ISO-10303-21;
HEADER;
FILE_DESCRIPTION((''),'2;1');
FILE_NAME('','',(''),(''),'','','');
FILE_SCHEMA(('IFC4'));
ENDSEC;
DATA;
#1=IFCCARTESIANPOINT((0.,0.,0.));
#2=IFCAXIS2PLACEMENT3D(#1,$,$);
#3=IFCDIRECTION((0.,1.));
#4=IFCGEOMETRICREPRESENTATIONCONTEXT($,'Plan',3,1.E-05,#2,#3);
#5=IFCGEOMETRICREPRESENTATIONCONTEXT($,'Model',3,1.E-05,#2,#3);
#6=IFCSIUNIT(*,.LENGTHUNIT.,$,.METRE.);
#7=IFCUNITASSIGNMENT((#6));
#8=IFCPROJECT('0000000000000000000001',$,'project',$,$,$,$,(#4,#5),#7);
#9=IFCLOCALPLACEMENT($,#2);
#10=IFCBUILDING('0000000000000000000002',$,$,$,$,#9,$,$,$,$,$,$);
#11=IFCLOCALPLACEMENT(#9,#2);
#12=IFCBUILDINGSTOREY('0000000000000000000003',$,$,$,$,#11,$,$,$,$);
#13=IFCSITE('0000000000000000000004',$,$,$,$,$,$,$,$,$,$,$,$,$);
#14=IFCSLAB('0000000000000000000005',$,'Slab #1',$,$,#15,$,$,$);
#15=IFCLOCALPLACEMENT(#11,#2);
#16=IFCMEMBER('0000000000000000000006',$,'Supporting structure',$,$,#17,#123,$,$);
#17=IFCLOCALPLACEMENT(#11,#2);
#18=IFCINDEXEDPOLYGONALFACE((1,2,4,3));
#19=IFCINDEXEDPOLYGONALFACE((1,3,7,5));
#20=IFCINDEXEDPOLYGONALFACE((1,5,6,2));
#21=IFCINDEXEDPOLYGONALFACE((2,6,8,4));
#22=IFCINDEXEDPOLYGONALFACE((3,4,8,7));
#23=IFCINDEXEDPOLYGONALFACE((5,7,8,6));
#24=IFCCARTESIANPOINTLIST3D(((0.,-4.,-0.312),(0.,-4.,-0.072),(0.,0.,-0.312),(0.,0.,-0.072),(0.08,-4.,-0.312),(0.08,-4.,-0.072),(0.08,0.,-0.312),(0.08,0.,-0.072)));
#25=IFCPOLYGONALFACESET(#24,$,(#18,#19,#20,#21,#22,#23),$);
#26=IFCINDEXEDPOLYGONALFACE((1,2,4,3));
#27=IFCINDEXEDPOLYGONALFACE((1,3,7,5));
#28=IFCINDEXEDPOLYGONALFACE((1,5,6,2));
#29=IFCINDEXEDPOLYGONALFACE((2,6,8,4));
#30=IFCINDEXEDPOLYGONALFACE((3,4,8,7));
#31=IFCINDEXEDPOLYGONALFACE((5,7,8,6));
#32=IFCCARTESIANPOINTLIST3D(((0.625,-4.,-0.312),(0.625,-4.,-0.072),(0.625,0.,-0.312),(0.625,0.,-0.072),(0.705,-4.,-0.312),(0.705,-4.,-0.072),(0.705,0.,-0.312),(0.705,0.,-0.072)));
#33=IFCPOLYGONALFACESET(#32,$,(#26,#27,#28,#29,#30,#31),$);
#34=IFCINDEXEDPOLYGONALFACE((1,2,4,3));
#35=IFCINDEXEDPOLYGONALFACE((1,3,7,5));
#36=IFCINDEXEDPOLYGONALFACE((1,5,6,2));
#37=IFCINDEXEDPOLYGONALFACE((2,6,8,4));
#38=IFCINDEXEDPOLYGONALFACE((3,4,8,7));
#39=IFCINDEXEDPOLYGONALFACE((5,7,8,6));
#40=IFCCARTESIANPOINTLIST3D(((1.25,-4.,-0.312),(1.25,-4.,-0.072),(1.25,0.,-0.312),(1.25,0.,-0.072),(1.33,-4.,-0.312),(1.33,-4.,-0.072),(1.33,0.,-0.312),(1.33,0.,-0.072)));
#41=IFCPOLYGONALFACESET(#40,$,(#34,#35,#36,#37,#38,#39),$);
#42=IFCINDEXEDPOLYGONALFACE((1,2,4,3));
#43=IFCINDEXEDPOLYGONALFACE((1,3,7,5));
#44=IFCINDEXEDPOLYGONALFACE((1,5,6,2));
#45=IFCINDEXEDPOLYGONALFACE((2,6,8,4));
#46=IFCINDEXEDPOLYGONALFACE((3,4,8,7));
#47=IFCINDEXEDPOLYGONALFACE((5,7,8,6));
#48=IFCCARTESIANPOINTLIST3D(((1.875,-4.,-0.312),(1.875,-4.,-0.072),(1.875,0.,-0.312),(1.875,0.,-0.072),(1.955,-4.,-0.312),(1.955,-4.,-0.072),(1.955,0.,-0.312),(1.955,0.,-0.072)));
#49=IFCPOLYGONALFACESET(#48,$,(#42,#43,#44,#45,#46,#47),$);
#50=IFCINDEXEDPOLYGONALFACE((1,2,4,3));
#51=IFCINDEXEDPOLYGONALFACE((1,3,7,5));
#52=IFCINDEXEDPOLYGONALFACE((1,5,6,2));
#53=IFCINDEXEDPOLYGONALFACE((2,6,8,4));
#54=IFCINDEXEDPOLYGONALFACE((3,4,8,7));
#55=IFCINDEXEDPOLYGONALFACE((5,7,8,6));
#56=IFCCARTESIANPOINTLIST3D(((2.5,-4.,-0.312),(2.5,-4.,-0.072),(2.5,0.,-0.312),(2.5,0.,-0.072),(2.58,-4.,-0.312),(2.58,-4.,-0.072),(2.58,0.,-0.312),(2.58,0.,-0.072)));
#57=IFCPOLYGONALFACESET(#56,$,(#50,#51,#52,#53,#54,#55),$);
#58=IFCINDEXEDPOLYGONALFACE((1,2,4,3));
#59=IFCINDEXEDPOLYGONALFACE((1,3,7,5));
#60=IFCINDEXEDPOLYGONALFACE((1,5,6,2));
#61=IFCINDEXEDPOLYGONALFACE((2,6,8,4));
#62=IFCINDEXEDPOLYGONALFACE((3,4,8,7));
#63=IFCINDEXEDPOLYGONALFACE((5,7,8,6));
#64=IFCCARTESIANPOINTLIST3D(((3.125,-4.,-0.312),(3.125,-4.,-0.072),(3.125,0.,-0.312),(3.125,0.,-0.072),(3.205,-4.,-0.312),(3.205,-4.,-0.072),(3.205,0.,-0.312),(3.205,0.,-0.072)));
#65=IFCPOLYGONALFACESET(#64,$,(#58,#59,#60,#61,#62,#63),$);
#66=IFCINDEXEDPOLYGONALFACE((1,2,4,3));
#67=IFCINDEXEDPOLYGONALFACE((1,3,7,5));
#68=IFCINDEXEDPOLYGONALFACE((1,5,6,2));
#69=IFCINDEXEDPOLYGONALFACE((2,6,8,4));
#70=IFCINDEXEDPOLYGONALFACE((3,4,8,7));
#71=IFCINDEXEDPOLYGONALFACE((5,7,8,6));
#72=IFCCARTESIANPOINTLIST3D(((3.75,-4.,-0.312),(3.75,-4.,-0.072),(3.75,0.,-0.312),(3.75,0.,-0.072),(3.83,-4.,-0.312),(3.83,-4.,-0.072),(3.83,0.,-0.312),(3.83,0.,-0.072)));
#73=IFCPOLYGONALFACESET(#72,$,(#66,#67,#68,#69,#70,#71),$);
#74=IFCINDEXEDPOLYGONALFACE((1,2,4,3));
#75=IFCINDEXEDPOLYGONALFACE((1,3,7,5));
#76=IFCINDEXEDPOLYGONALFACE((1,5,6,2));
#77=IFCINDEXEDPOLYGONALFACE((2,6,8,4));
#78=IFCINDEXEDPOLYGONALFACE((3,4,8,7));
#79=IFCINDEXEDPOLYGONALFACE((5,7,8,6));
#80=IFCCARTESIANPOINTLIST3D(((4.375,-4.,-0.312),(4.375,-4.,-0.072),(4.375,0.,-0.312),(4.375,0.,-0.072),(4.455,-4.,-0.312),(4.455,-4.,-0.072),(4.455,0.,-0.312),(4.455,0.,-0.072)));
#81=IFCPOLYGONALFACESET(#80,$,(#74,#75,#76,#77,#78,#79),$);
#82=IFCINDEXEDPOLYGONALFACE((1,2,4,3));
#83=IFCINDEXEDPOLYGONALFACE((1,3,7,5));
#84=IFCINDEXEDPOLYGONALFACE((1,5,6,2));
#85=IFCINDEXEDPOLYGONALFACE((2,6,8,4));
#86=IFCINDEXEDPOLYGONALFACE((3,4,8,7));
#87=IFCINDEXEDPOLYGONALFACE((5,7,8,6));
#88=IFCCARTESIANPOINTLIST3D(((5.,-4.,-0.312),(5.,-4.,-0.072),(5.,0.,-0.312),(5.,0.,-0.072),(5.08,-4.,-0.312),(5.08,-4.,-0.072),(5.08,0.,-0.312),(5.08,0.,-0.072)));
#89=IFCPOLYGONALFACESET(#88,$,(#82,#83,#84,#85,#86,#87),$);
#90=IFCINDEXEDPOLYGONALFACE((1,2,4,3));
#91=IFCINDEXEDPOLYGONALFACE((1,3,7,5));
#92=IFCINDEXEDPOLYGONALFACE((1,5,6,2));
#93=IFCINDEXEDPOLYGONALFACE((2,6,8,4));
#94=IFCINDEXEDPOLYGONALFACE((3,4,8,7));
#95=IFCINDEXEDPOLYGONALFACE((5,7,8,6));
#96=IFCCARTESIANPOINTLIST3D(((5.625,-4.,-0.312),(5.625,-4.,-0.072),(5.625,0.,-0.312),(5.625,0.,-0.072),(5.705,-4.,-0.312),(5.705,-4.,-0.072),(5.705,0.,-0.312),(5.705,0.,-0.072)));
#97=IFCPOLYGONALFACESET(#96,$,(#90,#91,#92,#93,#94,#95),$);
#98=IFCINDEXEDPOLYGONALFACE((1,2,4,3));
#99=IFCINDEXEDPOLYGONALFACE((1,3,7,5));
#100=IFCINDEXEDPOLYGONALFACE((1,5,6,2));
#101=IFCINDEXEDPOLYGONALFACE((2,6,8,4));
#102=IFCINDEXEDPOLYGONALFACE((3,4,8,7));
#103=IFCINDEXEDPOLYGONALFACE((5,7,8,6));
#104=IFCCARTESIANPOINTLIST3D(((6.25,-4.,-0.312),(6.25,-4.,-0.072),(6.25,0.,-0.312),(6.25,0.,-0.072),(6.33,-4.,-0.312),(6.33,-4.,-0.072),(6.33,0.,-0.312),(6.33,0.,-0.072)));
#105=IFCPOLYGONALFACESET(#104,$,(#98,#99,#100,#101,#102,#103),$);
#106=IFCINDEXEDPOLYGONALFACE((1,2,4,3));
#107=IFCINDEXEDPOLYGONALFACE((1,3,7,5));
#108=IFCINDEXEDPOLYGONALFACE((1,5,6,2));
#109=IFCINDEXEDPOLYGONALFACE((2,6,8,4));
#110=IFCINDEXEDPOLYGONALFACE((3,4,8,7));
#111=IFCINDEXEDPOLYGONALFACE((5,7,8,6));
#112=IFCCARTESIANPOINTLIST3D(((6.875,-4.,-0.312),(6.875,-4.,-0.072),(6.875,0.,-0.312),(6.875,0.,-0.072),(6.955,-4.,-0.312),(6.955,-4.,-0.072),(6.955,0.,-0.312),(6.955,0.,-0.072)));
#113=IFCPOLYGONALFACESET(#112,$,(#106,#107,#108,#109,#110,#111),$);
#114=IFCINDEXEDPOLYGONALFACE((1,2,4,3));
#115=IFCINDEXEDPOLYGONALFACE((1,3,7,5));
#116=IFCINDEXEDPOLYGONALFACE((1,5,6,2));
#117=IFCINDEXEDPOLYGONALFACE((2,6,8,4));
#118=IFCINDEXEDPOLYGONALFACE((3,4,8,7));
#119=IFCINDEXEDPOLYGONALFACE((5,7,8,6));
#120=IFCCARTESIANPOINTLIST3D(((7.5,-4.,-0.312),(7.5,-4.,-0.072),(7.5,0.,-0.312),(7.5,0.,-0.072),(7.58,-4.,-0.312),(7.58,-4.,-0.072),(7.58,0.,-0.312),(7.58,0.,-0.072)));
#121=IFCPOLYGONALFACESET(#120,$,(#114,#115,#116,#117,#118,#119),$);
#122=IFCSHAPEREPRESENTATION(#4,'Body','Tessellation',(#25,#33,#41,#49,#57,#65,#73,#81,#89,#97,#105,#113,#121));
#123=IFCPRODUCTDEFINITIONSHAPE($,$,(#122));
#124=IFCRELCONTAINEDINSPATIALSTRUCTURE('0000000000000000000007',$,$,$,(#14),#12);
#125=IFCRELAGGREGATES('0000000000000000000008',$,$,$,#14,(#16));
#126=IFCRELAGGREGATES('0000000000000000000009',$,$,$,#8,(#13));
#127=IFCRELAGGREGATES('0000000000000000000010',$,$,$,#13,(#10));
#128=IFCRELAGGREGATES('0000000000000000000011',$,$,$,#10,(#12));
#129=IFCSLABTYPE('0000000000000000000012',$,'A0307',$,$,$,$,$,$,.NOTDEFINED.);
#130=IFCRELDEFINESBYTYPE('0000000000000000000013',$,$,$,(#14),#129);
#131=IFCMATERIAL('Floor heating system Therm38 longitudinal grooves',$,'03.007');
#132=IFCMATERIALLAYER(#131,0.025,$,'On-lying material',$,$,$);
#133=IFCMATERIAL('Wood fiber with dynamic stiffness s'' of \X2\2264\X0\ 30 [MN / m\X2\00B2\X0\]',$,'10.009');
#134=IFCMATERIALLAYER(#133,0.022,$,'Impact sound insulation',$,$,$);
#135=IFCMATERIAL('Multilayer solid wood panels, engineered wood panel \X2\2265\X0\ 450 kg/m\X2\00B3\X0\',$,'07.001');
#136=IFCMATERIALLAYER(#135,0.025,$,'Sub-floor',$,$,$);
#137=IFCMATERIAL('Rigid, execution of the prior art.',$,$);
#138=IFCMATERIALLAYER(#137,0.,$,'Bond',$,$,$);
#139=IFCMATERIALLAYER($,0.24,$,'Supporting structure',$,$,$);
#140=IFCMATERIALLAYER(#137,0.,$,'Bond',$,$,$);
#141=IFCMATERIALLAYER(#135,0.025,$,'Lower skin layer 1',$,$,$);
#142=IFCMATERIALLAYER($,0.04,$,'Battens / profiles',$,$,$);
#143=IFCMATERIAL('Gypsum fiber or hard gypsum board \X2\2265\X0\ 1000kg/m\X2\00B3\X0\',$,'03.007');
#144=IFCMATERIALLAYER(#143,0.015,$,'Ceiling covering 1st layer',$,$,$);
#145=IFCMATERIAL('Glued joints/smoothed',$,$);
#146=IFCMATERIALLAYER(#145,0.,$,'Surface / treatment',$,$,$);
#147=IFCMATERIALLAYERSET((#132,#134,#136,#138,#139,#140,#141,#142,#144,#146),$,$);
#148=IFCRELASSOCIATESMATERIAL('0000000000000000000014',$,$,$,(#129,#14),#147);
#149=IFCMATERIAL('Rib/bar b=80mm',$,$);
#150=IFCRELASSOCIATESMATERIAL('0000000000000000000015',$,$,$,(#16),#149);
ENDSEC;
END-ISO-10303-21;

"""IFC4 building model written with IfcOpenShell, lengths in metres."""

from ifc_helpers import new_model, si_unit, direction, frame, frame_2d, origin, place, context, project, spatial, rectangle, extrude, material, layer, layer_set, type_object, element, aggregate, save


model = new_model("IFC4")

# Units and contexts
plan_context = context("Plan", 3, precision=1e-05, world=origin(), true_north=direction((0.0, 1.0)))
model_context = context("Model", 3, precision=1e-05, world=origin(), true_north=direction((0.0, 1.0)))
ifc_project = project(units=[si_unit("LENGTHUNIT", "METRE")], contexts=[plan_context, model_context])

# Site, building, storey
site = spatial("IfcSite", under=ifc_project)
building_placement = place(None, origin())
building = spatial("IfcBuilding", under=site, at=building_placement)
storey_placement = place(building_placement, origin())
storey = spatial("IfcBuildingStorey", under=building, at=storey_placement)

# Slab, member
ifc_material_1 = material(Name="Floor heating system Therm38 longitudinal grooves", Category="03.007")
ifc_layer_1 = layer(ifc_material_1, 0.025, Name="On-lying material")
ifc_material_2 = material(Name="Wood fiber with dynamic stiffness s' of ≤ 30 [MN / m²]", Category="10.009")
ifc_layer_2 = layer(ifc_material_2, 0.022, Name="Impact sound insulation")
ifc_material_3 = material(Name="Multilayer solid wood panels, engineered wood panel ≥ 450 kg/m³", Category="07.001")
ifc_layer_3 = layer(ifc_material_3, 0.025, Name="Sub-floor")
ifc_material_4 = material(Name="Rigid, execution of the prior art.")
ifc_layer_4 = layer(ifc_material_4, 0.0, Name="Bond")
ifc_layer_5 = layer(None, 0.24, Name="Supporting structure")
ifc_layer_6 = layer(ifc_material_4, 0.0, Name="Bond")
ifc_layer_7 = layer(ifc_material_3, 0.025, Name="Lower skin layer 1")
ifc_layer_8 = layer(None, 0.04, Name="Battens / profiles")
ifc_material_5 = material(Name="Gypsum fiber or hard gypsum board ≥ 1000kg/m³", Category="03.007")
ifc_layer_9 = layer(ifc_material_5, 0.015, Name="Ceiling covering 1st layer")
ifc_material_6 = material(Name="Glued joints/smoothed")
ifc_layer_10 = layer(ifc_material_6, 0.0, Name="Surface / treatment")
ifc_layer_set = layer_set([ifc_layer_1, ifc_layer_2, ifc_layer_3, ifc_layer_4, ifc_layer_5, ifc_layer_6, ifc_layer_7, ifc_layer_8, ifc_layer_9, ifc_layer_10])
slab_type = type_object("IfcSlabType", Name="A0307", PredefinedType="NOTDEFINED", material=ifc_layer_set)
slab_placement = place(None, frame((0.0, 0.0, 0.0), z_axis=(0.0, 0.0, -1.0), x_axis=(1.0, 0.0, 0.0)))
slab = element("IfcSlab", 1, at=slab_placement, inside=storey, type_object=slab_type, material=ifc_layer_set, Name="Slab #1")
ifc_material_7 = material(Name="Rib/bar b=80mm")
member_1_placement = place(slab_placement, origin())
member_1 = element("IfcMember", 2, at=member_1_placement, material=ifc_material_7, Name="Supporting structure", context=plan_context, shape_type="SweptSolid", body=[
    extrude(rectangle(XDim=0.08, YDim=0.24, at=frame_2d((0.04, 0.12), x_axis=(1.0, 0.0))), frame((0.0, 4.0, 0.072), z_axis=(0.0, -1.0, 0.0), x_axis=(1.0, 0.0, 0.0)), (0.0, 0.0, 1.0), 4.0),
    extrude(rectangle(XDim=0.08, YDim=0.24, at=frame_2d((0.04, 0.12), x_axis=(1.0, 0.0))), frame((0.625, 4.0, 0.072), z_axis=(0.0, -1.0, 0.0), x_axis=(1.0, 0.0, 0.0)), (0.0, 0.0, 1.0), 4.0),
    extrude(rectangle(XDim=0.08, YDim=0.24, at=frame_2d((0.04, 0.12), x_axis=(1.0, 0.0))), frame((1.25, 4.0, 0.072), z_axis=(0.0, -1.0, 0.0), x_axis=(1.0, 0.0, 0.0)), (0.0, 0.0, 1.0), 4.0),
    extrude(rectangle(XDim=0.08, YDim=0.24, at=frame_2d((0.04, 0.12), x_axis=(1.0, 0.0))), frame((1.875, 4.0, 0.072), z_axis=(0.0, -1.0, 0.0), x_axis=(1.0, 0.0, 0.0)), (0.0, 0.0, 1.0), 4.0),
    extrude(rectangle(XDim=0.08, YDim=0.24, at=frame_2d((0.04, 0.12), x_axis=(1.0, 0.0))), frame((2.5, 4.0, 0.072), z_axis=(0.0, -1.0, 0.0), x_axis=(1.0, 0.0, 0.0)), (0.0, 0.0, 1.0), 4.0),
    extrude(rectangle(XDim=0.08, YDim=0.24, at=frame_2d((0.04, 0.12), x_axis=(1.0, 0.0))), frame((3.125, 4.0, 0.072), z_axis=(0.0, -1.0, 0.0), x_axis=(1.0, 0.0, 0.0)), (0.0, 0.0, 1.0), 4.0),
    extrude(rectangle(XDim=0.08, YDim=0.24, at=frame_2d((0.04, 0.12), x_axis=(1.0, 0.0))), frame((3.75, 4.0, 0.072), z_axis=(0.0, -1.0, 0.0), x_axis=(1.0, 0.0, 0.0)), (0.0, 0.0, 1.0), 4.0),
    extrude(rectangle(XDim=0.08, YDim=0.24, at=frame_2d((0.04, 0.12), x_axis=(1.0, 0.0))), frame((4.375, 4.0, 0.072), z_axis=(0.0, -1.0, 0.0), x_axis=(1.0, 0.0, 0.0)), (0.0, 0.0, 1.0), 4.0),
    extrude(rectangle(XDim=0.08, YDim=0.24, at=frame_2d((0.04, 0.12), x_axis=(1.0, 0.0))), frame((5.0, 4.0, 0.072), z_axis=(0.0, -1.0, 0.0), x_axis=(1.0, 0.0, 0.0)), (0.0, 0.0, 1.0), 4.0),
    extrude(rectangle(XDim=0.08, YDim=0.24, at=frame_2d((0.04, 0.12), x_axis=(1.0, 0.0))), frame((5.625, 4.0, 0.072), z_axis=(0.0, -1.0, 0.0), x_axis=(1.0, 0.0, 0.0)), (0.0, 0.0, 1.0), 4.0),
    extrude(rectangle(XDim=0.08, YDim=0.24, at=frame_2d((0.04, 0.12), x_axis=(1.0, 0.0))), frame((6.25, 4.0, 0.072), z_axis=(0.0, -1.0, 0.0), x_axis=(1.0, 0.0, 0.0)), (0.0, 0.0, 1.0), 4.0),
    extrude(rectangle(XDim=0.08, YDim=0.24, at=frame_2d((0.04, 0.12), x_axis=(1.0, 0.0))), frame((6.875, 4.0, 0.072), z_axis=(0.0, -1.0, 0.0), x_axis=(1.0, 0.0, 0.0)), (0.0, 0.0, 1.0), 4.0),
    extrude(rectangle(XDim=0.08, YDim=0.24, at=frame_2d((0.04, 0.12), x_axis=(1.0, 0.0))), frame((7.5, 4.0, 0.072), z_axis=(0.0, -1.0, 0.0), x_axis=(1.0, 0.0, 0.0)), (0.0, 0.0, 1.0), 4.0),
])
aggregate(slab, [member_1])

save(model, "model.ifc")
